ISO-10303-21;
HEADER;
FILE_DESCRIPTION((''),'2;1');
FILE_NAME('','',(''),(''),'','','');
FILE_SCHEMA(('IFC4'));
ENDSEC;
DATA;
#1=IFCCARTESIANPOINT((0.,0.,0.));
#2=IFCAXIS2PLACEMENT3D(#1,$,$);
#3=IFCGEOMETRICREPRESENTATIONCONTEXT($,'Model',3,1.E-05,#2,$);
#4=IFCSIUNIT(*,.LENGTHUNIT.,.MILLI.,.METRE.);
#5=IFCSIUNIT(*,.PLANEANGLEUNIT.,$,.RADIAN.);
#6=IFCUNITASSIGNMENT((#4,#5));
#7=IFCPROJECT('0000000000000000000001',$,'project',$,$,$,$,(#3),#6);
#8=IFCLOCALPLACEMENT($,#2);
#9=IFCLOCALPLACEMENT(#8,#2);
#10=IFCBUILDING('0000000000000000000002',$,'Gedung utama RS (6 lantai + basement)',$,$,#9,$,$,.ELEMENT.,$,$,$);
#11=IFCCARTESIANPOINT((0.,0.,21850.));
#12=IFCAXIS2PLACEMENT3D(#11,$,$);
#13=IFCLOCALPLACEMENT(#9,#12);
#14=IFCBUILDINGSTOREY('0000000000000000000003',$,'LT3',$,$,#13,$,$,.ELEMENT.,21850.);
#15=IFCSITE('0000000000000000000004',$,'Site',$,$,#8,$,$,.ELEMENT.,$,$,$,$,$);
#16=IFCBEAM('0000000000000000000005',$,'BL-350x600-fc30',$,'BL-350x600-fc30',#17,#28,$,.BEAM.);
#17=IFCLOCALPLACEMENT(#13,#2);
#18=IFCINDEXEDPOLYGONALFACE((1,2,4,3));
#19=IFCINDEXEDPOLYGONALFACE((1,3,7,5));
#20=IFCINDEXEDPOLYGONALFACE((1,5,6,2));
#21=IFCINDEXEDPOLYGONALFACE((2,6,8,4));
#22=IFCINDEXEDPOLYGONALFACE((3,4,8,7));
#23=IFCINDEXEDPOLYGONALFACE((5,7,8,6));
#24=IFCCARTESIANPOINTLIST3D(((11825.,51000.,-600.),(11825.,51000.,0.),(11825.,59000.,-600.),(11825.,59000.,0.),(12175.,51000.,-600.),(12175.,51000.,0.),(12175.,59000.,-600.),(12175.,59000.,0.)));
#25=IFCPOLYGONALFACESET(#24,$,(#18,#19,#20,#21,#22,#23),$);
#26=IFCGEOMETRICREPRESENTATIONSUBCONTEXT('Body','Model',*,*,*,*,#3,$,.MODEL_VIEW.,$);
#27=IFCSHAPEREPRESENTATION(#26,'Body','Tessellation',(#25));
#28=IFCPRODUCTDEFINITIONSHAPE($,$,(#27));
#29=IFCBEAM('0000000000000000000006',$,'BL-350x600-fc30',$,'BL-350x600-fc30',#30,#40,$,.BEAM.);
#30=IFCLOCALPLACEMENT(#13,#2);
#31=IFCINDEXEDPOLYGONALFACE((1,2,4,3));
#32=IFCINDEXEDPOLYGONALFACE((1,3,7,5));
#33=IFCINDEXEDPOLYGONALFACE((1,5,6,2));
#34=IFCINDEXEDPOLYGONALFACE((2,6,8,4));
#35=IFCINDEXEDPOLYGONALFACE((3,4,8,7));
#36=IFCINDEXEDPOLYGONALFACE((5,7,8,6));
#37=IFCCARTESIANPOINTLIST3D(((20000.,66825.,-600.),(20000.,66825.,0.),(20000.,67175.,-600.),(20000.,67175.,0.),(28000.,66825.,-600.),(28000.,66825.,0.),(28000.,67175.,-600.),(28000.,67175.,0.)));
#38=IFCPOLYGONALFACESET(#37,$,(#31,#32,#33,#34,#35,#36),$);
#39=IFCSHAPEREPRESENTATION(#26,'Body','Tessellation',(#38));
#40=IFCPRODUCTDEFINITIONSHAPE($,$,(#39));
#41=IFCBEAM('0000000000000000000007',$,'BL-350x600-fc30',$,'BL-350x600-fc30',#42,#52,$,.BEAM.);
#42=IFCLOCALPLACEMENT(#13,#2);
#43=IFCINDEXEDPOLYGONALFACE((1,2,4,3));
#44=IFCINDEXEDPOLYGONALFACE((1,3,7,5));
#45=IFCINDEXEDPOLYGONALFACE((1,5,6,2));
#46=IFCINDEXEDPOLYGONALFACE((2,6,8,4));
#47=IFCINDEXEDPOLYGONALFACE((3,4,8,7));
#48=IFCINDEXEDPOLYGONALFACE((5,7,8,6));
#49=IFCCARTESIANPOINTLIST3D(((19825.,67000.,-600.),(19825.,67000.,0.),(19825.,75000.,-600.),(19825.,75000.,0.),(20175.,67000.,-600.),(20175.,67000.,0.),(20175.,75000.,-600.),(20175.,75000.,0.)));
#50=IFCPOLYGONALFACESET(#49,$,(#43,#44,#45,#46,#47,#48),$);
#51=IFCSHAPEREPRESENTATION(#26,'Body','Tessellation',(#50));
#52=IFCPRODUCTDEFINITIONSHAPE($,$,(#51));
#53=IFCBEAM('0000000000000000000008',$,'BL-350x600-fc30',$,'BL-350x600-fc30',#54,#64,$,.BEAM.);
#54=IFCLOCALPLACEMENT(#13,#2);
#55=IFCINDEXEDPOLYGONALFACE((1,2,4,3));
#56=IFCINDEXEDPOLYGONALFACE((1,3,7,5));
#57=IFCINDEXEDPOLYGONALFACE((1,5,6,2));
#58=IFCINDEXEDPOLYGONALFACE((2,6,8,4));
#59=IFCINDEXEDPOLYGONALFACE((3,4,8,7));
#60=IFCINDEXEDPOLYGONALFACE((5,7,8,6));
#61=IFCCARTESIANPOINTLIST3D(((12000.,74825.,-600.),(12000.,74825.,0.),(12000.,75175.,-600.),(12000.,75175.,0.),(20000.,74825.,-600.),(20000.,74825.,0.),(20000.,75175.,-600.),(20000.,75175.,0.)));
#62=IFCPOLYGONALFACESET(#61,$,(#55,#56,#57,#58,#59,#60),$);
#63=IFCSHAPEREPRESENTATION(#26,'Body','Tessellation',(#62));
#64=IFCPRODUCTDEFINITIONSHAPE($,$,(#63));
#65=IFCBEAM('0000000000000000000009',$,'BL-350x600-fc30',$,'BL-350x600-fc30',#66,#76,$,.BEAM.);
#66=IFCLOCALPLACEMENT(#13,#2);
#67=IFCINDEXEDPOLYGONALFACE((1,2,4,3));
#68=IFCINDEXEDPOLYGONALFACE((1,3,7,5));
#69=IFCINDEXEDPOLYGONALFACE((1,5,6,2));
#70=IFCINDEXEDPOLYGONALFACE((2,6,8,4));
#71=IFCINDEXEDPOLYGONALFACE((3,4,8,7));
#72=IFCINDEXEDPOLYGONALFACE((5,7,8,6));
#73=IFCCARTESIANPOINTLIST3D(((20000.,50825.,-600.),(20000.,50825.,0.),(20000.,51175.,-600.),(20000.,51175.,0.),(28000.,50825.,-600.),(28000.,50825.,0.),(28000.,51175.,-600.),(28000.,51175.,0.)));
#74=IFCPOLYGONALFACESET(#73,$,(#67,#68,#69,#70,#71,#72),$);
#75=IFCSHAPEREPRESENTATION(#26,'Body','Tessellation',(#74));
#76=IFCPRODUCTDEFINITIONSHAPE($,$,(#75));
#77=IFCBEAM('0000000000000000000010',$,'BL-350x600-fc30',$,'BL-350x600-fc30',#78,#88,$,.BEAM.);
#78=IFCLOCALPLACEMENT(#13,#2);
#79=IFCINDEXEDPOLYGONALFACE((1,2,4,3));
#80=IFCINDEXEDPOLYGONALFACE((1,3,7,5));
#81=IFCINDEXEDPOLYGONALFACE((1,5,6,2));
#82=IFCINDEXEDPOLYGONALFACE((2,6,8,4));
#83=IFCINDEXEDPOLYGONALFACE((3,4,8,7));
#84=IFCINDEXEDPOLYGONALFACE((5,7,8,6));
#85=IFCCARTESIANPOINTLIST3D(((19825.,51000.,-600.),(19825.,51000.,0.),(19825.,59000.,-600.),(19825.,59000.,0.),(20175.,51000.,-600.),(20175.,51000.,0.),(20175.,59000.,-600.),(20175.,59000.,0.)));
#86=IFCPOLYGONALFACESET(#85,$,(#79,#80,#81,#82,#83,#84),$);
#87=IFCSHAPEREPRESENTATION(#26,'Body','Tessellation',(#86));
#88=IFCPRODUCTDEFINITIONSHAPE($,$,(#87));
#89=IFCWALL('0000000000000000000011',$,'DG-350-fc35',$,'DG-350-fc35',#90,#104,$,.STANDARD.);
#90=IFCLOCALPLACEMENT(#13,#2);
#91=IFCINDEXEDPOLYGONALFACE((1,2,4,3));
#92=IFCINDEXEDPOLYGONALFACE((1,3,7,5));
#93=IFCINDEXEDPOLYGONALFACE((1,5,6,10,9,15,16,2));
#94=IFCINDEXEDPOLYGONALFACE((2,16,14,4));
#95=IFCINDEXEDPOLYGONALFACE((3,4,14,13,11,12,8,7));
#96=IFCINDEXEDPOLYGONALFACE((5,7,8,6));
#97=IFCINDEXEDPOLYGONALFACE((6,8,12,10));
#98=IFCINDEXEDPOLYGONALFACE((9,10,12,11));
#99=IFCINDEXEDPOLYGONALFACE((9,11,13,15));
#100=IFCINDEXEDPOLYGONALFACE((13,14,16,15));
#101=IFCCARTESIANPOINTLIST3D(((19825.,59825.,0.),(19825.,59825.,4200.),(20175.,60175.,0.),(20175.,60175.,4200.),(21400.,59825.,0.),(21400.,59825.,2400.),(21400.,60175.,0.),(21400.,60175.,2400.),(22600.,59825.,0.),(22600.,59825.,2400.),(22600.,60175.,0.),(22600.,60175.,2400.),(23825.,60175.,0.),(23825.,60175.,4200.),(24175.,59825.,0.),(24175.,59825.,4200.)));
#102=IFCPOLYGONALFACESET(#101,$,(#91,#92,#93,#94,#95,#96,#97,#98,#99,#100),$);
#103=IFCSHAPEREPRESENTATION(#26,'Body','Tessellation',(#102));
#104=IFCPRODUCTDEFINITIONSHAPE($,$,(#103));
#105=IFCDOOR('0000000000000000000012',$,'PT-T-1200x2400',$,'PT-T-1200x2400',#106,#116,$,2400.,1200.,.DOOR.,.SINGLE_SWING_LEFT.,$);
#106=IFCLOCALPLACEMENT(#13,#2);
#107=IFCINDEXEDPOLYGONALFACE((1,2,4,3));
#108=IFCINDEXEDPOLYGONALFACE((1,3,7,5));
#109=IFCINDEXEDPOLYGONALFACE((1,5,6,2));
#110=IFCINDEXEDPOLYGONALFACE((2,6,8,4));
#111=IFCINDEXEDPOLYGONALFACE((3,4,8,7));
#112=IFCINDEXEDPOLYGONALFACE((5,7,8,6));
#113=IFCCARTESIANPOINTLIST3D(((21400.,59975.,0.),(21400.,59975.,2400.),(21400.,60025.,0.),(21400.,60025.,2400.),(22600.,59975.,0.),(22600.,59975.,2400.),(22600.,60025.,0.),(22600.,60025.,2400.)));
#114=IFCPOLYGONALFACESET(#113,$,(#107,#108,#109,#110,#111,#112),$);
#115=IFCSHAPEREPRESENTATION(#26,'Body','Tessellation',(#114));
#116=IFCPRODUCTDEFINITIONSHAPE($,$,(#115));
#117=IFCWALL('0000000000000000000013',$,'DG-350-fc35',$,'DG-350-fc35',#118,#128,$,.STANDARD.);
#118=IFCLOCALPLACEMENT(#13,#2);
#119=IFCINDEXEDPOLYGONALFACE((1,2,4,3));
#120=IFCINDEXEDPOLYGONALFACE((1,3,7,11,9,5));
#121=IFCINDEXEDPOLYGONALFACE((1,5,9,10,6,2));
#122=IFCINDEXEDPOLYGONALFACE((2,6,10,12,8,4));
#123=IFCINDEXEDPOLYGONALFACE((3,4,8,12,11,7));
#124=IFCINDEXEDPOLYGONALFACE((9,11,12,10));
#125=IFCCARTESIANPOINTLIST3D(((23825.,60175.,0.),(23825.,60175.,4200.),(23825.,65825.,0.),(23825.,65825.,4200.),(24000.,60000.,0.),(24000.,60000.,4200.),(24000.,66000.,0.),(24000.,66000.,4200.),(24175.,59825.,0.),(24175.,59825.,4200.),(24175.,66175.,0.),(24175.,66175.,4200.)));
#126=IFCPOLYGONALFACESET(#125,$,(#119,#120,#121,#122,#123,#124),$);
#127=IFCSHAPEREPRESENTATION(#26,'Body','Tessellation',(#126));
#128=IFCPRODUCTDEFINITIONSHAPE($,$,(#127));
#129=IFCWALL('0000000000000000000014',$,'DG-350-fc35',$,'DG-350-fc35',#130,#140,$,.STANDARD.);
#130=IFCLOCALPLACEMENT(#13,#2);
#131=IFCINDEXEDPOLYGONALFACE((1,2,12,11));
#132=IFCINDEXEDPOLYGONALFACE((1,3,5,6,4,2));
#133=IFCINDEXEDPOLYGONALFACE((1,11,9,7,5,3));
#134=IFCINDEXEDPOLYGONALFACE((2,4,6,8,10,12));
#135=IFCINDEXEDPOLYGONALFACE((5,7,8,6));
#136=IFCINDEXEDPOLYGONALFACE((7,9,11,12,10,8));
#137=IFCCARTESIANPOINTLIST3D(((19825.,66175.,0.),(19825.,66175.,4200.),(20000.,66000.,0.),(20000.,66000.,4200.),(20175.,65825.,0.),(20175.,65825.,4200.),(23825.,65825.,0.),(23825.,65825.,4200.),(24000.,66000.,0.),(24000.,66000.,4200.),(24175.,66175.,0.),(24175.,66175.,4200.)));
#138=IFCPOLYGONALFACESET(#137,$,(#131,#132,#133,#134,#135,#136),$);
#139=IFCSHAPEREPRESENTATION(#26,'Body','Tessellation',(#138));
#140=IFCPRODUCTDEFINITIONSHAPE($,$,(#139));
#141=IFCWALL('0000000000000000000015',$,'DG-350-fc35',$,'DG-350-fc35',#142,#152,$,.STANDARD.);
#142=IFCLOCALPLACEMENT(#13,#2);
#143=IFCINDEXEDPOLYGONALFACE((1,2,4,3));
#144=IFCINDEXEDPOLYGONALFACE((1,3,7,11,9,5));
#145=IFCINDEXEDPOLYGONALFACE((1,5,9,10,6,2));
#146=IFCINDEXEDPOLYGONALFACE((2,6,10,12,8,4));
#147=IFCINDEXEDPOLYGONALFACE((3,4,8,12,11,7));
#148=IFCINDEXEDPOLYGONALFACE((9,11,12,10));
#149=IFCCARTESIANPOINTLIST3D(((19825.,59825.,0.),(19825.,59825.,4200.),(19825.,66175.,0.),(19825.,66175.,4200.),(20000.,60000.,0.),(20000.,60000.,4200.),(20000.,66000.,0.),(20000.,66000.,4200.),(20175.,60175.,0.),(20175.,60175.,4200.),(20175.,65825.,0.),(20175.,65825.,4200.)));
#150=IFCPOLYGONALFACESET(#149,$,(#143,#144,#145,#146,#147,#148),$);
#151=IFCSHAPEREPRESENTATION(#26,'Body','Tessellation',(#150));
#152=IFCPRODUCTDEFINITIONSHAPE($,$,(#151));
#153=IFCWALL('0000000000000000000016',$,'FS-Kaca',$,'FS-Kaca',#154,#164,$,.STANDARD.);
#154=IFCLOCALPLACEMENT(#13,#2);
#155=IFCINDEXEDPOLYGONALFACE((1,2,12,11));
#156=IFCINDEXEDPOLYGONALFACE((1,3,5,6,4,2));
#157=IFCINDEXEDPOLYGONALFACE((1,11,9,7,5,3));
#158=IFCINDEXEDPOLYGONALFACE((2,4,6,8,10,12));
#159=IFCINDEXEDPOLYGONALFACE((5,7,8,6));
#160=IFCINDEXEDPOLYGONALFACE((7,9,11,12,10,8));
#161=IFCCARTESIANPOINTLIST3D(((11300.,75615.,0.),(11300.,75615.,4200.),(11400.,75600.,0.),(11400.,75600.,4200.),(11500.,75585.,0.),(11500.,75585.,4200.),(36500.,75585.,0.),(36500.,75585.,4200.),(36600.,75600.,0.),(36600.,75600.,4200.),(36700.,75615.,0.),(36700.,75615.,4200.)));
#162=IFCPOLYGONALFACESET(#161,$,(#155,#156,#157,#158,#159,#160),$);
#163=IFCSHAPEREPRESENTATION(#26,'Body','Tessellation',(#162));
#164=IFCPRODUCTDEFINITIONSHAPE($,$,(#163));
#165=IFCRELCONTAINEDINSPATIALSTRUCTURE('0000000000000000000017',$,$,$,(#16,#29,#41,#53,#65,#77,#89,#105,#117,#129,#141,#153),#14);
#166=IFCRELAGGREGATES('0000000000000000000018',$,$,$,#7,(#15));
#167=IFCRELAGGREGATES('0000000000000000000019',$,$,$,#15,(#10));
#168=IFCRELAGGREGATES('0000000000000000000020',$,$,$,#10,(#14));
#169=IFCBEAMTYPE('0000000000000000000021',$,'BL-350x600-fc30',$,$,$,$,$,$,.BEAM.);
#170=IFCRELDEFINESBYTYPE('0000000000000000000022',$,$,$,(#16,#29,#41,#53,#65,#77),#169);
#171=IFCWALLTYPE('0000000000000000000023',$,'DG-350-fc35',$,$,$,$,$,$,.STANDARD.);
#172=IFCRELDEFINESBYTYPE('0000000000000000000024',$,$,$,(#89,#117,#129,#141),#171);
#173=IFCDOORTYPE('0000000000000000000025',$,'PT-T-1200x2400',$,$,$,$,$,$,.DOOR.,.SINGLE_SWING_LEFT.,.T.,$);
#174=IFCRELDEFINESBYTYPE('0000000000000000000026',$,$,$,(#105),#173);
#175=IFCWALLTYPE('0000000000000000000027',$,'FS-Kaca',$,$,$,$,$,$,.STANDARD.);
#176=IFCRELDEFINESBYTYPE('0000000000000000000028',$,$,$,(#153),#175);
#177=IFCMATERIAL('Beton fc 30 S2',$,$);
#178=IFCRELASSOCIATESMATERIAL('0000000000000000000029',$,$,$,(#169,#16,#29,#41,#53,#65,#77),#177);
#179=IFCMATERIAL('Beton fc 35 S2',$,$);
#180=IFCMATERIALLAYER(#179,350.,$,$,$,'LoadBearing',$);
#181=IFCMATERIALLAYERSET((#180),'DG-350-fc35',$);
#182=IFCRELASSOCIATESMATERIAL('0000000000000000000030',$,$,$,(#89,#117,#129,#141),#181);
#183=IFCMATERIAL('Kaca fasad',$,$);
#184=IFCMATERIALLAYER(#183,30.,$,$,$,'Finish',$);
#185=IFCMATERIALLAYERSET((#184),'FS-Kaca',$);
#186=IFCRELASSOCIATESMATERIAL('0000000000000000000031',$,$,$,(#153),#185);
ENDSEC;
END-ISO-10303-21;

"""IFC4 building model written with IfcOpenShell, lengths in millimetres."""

from ifc_helpers import new_model, si_unit, frame, frame_2d, origin, origin_2d, place, context, subcontext, project, spatial, polyline, rectangle, outline, extrude, material, layer, layer_set, layer_usage, material_profile, profile_set, profile_usage, type_object, element, fill, save


model = new_model("IFC4")

# Units and contexts
model_context = context("Model", 3, precision=1e-05, world=origin())
body_context = subcontext(model_context, "Body", "Model", "MODEL_VIEW")
ifc_project = project(units=[si_unit("LENGTHUNIT", "METRE", prefix="MILLI"), si_unit("PLANEANGLEUNIT", "RADIAN")], contexts=[model_context])

# Site, building, storey
site_placement = place(None, origin())
site = spatial("IfcSite", under=ifc_project, at=site_placement, Name="Site", CompositionType="ELEMENT")
building_placement = place(site_placement, origin())
building = spatial("IfcBuilding", under=site, at=building_placement, Name="Gedung utama RS (6 lantai + basement)", CompositionType="ELEMENT")
storey_placement = place(building_placement, frame((0.0, 0.0, 21850.0)))
storey = spatial("IfcBuildingStorey", under=building, at=storey_placement, Name="LT3", CompositionType="ELEMENT", Elevation=21850.0)

# Beams
ifc_material_1 = material(Name="Beton fc 30 S2")
ifc_material_profile_1 = material_profile(ifc_material_1, rectangle(XDim=350.0, YDim=600.0, at=origin_2d()), Name="BL-350x600-fc30")
ifc_profile_set_1 = profile_set([ifc_material_profile_1], Name="BL-350x600-fc30")
ifc_profile_usage_1 = profile_usage(ifc_profile_set_1, cardinal=8)
beam_type = type_object("IfcBeamType", Name="BL-350x600-fc30", PredefinedType="BEAM", material=ifc_profile_set_1)
beam_1_placement = place(storey_placement, frame((12000.0, 51000.0, -300.0)))
element("IfcBeam", 1, at=beam_1_placement, inside=storey, type_object=beam_type, material=ifc_profile_usage_1, Name="BL-350x600-fc30", ObjectType="BL-350x600-fc30", PredefinedType="BEAM", context=body_context, shape_type="SweptSolid", body=[
    extrude(rectangle(XDim=350.0, YDim=600.0, at=origin_2d()), frame((0.0, 0.0, 0.0), z_axis=(0.0, 1.0, 0.0), x_axis=(-1.0, 0.0, 0.0)), (0.0, 0.0, 1.0), 8000.0),
])
beam_2_placement = place(storey_placement, frame((20000.0, 67000.0, -300.0)))
element("IfcBeam", 2, at=beam_2_placement, inside=storey, type_object=beam_type, material=ifc_profile_usage_1, Name="BL-350x600-fc30", ObjectType="BL-350x600-fc30", PredefinedType="BEAM", context=body_context, shape_type="SweptSolid", body=[
    extrude(rectangle(XDim=350.0, YDim=600.0, at=origin_2d()), frame((0.0, 0.0, 0.0), z_axis=(1.0, 0.0, 0.0), x_axis=(0.0, 1.0, 0.0)), (0.0, 0.0, 1.0), 8000.0),
])
beam_3_placement = place(storey_placement, frame((20000.0, 67000.0, -300.0)))
element("IfcBeam", 3, at=beam_3_placement, inside=storey, type_object=beam_type, material=ifc_profile_usage_1, Name="BL-350x600-fc30", ObjectType="BL-350x600-fc30", PredefinedType="BEAM", context=body_context, shape_type="SweptSolid", body=[
    extrude(rectangle(XDim=350.0, YDim=600.0, at=origin_2d()), frame((0.0, 0.0, 0.0), z_axis=(0.0, 1.0, 0.0), x_axis=(-1.0, 0.0, 0.0)), (0.0, 0.0, 1.0), 8000.0),
])
for number, where, name in (
    (4, (12000.0, 75000.0, -300.0), "BL-350x600-fc30"),
    (5, (20000.0, 51000.0, -300.0), "BL-350x600-fc30"),
):
    element("IfcBeam", number, at=place(storey_placement, frame(where)), inside=storey, type_object=beam_type, material=ifc_profile_usage_1, Name=name, ObjectType="BL-350x600-fc30", PredefinedType="BEAM", context=body_context, shape_type="SweptSolid", body=[
        extrude(rectangle(XDim=350.0, YDim=600.0, at=origin_2d()), frame((0.0, 0.0, 0.0), z_axis=(1.0, 0.0, 0.0), x_axis=(0.0, 1.0, 0.0)), (0.0, 0.0, 1.0), 8000.0),
    ])
beam_4_placement = place(storey_placement, frame((20000.0, 51000.0, -300.0)))
element("IfcBeam", 6, at=beam_4_placement, inside=storey, type_object=beam_type, material=ifc_profile_usage_1, Name="BL-350x600-fc30", ObjectType="BL-350x600-fc30", PredefinedType="BEAM", context=body_context, shape_type="SweptSolid", body=[
    extrude(rectangle(XDim=350.0, YDim=600.0, at=origin_2d()), frame((0.0, 0.0, 0.0), z_axis=(0.0, 1.0, 0.0), x_axis=(-1.0, 0.0, 0.0)), (0.0, 0.0, 1.0), 8000.0),
])

# Wall, opening, door
ifc_material_2 = material(Name="Beton fc 35 S2")
ifc_layer_1 = layer(ifc_material_2, 350.0, Category="LoadBearing")
ifc_layer_set_1 = layer_set([ifc_layer_1], Name="DG-350-fc35")
ifc_layer_usage_1 = layer_usage(ifc_layer_set_1, "AXIS2", "NEGATIVE", 175.0)
wall_type_1 = type_object("IfcWallType", Name="DG-350-fc35", PredefinedType="STANDARD")
wall_1_placement = place(storey_placement, frame((20000.0, 60000.0, 0.0), z_axis=(0.0, 0.0, 1.0), x_axis=(1.0, 0.0, 0.0)))
wall_1 = element("IfcWall", 7, at=wall_1_placement, inside=storey, type_object=wall_type_1, material=ifc_layer_usage_1, Name="DG-350-fc35", ObjectType="DG-350-fc35", PredefinedType="STANDARD", context=body_context, shape_type="SweptSolid", body=[
    extrude(outline(polyline([(-175.0, -175.0), (0.0, 0.0), (175.0, 175.0), (3825.0, 175.0), (4000.0, 0.0), (4175.0, -175.0), (-175.0, -175.0)])), origin(), (0.0, 0.0, 1.0), 4200.0),
])
opening_placement = place(wall_1_placement, frame((1400.0, 0.0, 0.0), z_axis=(0.0, 0.0, 1.0), x_axis=(1.0, 0.0, 0.0)))
opening = element("IfcOpeningElement", 8, at=opening_placement, cuts=wall_1, PredefinedType="OPENING", context=body_context, shape_type="SweptSolid", body=[
    extrude(rectangle(XDim=1200.0, YDim=370.0, at=frame_2d((600.0, 0.0))), origin(), (0.0, 0.0, 1.0), 2400.0),
])
door_type = type_object("IfcDoorType", Name="PT-T-1200x2400", OperationType="SINGLE_SWING_LEFT", ParameterTakesPrecedence=True, PredefinedType="DOOR")
door_placement = place(opening_placement, origin())
door = element("IfcDoor", 9, at=door_placement, inside=storey, type_object=door_type, Name="PT-T-1200x2400", ObjectType="PT-T-1200x2400", OperationType="SINGLE_SWING_LEFT", OverallHeight=2400.0, OverallWidth=1200.0, PredefinedType="DOOR", context=body_context, shape_type="SweptSolid", body=[
    extrude(rectangle(XDim=1200.0, YDim=50.0, at=frame_2d((600.0, 0.0))), origin(), (0.0, 0.0, 1.0), 2400.0),
])
fill(opening, door)

# Walls
wall_2_placement = place(storey_placement, frame((24000.0, 60000.0, 0.0), z_axis=(0.0, 0.0, 1.0), x_axis=(0.0, 1.0, 0.0)))
element("IfcWall", 10, at=wall_2_placement, inside=storey, type_object=wall_type_1, material=ifc_layer_usage_1, Name="DG-350-fc35", ObjectType="DG-350-fc35", PredefinedType="STANDARD", context=body_context, shape_type="SweptSolid", body=[
    extrude(outline(polyline([(-175.0, -175.0), (0.0, 0.0), (175.0, 175.0), (5825.0, 175.0), (6000.0, 0.0), (6175.0, -175.0), (-175.0, -175.0)])), origin(), (0.0, 0.0, 1.0), 4200.0),
])
wall_3_placement = place(storey_placement, frame((24000.0, 66000.0, 0.0), z_axis=(0.0, 0.0, 1.0), x_axis=(-1.0, 0.0, 0.0)))
element("IfcWall", 11, at=wall_3_placement, inside=storey, type_object=wall_type_1, material=ifc_layer_usage_1, Name="DG-350-fc35", ObjectType="DG-350-fc35", PredefinedType="STANDARD", context=body_context, shape_type="SweptSolid", body=[
    extrude(outline(polyline([(-175.0, -175.0), (0.0, 0.0), (175.0, 175.0), (3825.0, 175.0), (4000.0, 0.0), (4175.0, -175.0), (-175.0, -175.0)])), origin(), (0.0, 0.0, 1.0), 4200.0),
])
wall_4_placement = place(storey_placement, frame((20000.0, 66000.0, 0.0), z_axis=(0.0, 0.0, 1.0), x_axis=(0.0, -1.0, 0.0)))
element("IfcWall", 12, at=wall_4_placement, inside=storey, type_object=wall_type_1, material=ifc_layer_usage_1, Name="DG-350-fc35", ObjectType="DG-350-fc35", PredefinedType="STANDARD", context=body_context, shape_type="SweptSolid", body=[
    extrude(outline(polyline([(-175.0, -175.0), (0.0, 0.0), (175.0, 175.0), (5825.0, 175.0), (6000.0, 0.0), (6175.0, -175.0), (-175.0, -175.0)])), origin(), (0.0, 0.0, 1.0), 4200.0),
])
ifc_material_3 = material(Name="Kaca fasad")
ifc_layer_2 = layer(ifc_material_3, 30.0, Category="Finish")
ifc_layer_set_2 = layer_set([ifc_layer_2], Name="FS-Kaca")
ifc_layer_usage_2 = layer_usage(ifc_layer_set_2, "AXIS2", "NEGATIVE", 15.0)
wall_type_2 = type_object("IfcWallType", Name="FS-Kaca", PredefinedType="STANDARD")
wall_5_placement = place(storey_placement, frame((11400.0, 75600.0, 0.0), z_axis=(0.0, 0.0, 1.0), x_axis=(1.0, 0.0, 0.0)))
element("IfcWall", 13, at=wall_5_placement, inside=storey, type_object=wall_type_2, material=ifc_layer_usage_2, Name="FS-Kaca", ObjectType="FS-Kaca", PredefinedType="STANDARD", context=body_context, shape_type="SweptSolid", body=[
    extrude(outline(polyline([(100.0, -15.0), (0.0, 0.0), (-100.0, 15.0), (25300.0, 15.0), (25200.0, 0.0), (25100.0, -15.0), (100.0, -15.0)])), origin(), (0.0, 0.0, 1.0), 4200.0),
])

save(model, "model.ifc")
